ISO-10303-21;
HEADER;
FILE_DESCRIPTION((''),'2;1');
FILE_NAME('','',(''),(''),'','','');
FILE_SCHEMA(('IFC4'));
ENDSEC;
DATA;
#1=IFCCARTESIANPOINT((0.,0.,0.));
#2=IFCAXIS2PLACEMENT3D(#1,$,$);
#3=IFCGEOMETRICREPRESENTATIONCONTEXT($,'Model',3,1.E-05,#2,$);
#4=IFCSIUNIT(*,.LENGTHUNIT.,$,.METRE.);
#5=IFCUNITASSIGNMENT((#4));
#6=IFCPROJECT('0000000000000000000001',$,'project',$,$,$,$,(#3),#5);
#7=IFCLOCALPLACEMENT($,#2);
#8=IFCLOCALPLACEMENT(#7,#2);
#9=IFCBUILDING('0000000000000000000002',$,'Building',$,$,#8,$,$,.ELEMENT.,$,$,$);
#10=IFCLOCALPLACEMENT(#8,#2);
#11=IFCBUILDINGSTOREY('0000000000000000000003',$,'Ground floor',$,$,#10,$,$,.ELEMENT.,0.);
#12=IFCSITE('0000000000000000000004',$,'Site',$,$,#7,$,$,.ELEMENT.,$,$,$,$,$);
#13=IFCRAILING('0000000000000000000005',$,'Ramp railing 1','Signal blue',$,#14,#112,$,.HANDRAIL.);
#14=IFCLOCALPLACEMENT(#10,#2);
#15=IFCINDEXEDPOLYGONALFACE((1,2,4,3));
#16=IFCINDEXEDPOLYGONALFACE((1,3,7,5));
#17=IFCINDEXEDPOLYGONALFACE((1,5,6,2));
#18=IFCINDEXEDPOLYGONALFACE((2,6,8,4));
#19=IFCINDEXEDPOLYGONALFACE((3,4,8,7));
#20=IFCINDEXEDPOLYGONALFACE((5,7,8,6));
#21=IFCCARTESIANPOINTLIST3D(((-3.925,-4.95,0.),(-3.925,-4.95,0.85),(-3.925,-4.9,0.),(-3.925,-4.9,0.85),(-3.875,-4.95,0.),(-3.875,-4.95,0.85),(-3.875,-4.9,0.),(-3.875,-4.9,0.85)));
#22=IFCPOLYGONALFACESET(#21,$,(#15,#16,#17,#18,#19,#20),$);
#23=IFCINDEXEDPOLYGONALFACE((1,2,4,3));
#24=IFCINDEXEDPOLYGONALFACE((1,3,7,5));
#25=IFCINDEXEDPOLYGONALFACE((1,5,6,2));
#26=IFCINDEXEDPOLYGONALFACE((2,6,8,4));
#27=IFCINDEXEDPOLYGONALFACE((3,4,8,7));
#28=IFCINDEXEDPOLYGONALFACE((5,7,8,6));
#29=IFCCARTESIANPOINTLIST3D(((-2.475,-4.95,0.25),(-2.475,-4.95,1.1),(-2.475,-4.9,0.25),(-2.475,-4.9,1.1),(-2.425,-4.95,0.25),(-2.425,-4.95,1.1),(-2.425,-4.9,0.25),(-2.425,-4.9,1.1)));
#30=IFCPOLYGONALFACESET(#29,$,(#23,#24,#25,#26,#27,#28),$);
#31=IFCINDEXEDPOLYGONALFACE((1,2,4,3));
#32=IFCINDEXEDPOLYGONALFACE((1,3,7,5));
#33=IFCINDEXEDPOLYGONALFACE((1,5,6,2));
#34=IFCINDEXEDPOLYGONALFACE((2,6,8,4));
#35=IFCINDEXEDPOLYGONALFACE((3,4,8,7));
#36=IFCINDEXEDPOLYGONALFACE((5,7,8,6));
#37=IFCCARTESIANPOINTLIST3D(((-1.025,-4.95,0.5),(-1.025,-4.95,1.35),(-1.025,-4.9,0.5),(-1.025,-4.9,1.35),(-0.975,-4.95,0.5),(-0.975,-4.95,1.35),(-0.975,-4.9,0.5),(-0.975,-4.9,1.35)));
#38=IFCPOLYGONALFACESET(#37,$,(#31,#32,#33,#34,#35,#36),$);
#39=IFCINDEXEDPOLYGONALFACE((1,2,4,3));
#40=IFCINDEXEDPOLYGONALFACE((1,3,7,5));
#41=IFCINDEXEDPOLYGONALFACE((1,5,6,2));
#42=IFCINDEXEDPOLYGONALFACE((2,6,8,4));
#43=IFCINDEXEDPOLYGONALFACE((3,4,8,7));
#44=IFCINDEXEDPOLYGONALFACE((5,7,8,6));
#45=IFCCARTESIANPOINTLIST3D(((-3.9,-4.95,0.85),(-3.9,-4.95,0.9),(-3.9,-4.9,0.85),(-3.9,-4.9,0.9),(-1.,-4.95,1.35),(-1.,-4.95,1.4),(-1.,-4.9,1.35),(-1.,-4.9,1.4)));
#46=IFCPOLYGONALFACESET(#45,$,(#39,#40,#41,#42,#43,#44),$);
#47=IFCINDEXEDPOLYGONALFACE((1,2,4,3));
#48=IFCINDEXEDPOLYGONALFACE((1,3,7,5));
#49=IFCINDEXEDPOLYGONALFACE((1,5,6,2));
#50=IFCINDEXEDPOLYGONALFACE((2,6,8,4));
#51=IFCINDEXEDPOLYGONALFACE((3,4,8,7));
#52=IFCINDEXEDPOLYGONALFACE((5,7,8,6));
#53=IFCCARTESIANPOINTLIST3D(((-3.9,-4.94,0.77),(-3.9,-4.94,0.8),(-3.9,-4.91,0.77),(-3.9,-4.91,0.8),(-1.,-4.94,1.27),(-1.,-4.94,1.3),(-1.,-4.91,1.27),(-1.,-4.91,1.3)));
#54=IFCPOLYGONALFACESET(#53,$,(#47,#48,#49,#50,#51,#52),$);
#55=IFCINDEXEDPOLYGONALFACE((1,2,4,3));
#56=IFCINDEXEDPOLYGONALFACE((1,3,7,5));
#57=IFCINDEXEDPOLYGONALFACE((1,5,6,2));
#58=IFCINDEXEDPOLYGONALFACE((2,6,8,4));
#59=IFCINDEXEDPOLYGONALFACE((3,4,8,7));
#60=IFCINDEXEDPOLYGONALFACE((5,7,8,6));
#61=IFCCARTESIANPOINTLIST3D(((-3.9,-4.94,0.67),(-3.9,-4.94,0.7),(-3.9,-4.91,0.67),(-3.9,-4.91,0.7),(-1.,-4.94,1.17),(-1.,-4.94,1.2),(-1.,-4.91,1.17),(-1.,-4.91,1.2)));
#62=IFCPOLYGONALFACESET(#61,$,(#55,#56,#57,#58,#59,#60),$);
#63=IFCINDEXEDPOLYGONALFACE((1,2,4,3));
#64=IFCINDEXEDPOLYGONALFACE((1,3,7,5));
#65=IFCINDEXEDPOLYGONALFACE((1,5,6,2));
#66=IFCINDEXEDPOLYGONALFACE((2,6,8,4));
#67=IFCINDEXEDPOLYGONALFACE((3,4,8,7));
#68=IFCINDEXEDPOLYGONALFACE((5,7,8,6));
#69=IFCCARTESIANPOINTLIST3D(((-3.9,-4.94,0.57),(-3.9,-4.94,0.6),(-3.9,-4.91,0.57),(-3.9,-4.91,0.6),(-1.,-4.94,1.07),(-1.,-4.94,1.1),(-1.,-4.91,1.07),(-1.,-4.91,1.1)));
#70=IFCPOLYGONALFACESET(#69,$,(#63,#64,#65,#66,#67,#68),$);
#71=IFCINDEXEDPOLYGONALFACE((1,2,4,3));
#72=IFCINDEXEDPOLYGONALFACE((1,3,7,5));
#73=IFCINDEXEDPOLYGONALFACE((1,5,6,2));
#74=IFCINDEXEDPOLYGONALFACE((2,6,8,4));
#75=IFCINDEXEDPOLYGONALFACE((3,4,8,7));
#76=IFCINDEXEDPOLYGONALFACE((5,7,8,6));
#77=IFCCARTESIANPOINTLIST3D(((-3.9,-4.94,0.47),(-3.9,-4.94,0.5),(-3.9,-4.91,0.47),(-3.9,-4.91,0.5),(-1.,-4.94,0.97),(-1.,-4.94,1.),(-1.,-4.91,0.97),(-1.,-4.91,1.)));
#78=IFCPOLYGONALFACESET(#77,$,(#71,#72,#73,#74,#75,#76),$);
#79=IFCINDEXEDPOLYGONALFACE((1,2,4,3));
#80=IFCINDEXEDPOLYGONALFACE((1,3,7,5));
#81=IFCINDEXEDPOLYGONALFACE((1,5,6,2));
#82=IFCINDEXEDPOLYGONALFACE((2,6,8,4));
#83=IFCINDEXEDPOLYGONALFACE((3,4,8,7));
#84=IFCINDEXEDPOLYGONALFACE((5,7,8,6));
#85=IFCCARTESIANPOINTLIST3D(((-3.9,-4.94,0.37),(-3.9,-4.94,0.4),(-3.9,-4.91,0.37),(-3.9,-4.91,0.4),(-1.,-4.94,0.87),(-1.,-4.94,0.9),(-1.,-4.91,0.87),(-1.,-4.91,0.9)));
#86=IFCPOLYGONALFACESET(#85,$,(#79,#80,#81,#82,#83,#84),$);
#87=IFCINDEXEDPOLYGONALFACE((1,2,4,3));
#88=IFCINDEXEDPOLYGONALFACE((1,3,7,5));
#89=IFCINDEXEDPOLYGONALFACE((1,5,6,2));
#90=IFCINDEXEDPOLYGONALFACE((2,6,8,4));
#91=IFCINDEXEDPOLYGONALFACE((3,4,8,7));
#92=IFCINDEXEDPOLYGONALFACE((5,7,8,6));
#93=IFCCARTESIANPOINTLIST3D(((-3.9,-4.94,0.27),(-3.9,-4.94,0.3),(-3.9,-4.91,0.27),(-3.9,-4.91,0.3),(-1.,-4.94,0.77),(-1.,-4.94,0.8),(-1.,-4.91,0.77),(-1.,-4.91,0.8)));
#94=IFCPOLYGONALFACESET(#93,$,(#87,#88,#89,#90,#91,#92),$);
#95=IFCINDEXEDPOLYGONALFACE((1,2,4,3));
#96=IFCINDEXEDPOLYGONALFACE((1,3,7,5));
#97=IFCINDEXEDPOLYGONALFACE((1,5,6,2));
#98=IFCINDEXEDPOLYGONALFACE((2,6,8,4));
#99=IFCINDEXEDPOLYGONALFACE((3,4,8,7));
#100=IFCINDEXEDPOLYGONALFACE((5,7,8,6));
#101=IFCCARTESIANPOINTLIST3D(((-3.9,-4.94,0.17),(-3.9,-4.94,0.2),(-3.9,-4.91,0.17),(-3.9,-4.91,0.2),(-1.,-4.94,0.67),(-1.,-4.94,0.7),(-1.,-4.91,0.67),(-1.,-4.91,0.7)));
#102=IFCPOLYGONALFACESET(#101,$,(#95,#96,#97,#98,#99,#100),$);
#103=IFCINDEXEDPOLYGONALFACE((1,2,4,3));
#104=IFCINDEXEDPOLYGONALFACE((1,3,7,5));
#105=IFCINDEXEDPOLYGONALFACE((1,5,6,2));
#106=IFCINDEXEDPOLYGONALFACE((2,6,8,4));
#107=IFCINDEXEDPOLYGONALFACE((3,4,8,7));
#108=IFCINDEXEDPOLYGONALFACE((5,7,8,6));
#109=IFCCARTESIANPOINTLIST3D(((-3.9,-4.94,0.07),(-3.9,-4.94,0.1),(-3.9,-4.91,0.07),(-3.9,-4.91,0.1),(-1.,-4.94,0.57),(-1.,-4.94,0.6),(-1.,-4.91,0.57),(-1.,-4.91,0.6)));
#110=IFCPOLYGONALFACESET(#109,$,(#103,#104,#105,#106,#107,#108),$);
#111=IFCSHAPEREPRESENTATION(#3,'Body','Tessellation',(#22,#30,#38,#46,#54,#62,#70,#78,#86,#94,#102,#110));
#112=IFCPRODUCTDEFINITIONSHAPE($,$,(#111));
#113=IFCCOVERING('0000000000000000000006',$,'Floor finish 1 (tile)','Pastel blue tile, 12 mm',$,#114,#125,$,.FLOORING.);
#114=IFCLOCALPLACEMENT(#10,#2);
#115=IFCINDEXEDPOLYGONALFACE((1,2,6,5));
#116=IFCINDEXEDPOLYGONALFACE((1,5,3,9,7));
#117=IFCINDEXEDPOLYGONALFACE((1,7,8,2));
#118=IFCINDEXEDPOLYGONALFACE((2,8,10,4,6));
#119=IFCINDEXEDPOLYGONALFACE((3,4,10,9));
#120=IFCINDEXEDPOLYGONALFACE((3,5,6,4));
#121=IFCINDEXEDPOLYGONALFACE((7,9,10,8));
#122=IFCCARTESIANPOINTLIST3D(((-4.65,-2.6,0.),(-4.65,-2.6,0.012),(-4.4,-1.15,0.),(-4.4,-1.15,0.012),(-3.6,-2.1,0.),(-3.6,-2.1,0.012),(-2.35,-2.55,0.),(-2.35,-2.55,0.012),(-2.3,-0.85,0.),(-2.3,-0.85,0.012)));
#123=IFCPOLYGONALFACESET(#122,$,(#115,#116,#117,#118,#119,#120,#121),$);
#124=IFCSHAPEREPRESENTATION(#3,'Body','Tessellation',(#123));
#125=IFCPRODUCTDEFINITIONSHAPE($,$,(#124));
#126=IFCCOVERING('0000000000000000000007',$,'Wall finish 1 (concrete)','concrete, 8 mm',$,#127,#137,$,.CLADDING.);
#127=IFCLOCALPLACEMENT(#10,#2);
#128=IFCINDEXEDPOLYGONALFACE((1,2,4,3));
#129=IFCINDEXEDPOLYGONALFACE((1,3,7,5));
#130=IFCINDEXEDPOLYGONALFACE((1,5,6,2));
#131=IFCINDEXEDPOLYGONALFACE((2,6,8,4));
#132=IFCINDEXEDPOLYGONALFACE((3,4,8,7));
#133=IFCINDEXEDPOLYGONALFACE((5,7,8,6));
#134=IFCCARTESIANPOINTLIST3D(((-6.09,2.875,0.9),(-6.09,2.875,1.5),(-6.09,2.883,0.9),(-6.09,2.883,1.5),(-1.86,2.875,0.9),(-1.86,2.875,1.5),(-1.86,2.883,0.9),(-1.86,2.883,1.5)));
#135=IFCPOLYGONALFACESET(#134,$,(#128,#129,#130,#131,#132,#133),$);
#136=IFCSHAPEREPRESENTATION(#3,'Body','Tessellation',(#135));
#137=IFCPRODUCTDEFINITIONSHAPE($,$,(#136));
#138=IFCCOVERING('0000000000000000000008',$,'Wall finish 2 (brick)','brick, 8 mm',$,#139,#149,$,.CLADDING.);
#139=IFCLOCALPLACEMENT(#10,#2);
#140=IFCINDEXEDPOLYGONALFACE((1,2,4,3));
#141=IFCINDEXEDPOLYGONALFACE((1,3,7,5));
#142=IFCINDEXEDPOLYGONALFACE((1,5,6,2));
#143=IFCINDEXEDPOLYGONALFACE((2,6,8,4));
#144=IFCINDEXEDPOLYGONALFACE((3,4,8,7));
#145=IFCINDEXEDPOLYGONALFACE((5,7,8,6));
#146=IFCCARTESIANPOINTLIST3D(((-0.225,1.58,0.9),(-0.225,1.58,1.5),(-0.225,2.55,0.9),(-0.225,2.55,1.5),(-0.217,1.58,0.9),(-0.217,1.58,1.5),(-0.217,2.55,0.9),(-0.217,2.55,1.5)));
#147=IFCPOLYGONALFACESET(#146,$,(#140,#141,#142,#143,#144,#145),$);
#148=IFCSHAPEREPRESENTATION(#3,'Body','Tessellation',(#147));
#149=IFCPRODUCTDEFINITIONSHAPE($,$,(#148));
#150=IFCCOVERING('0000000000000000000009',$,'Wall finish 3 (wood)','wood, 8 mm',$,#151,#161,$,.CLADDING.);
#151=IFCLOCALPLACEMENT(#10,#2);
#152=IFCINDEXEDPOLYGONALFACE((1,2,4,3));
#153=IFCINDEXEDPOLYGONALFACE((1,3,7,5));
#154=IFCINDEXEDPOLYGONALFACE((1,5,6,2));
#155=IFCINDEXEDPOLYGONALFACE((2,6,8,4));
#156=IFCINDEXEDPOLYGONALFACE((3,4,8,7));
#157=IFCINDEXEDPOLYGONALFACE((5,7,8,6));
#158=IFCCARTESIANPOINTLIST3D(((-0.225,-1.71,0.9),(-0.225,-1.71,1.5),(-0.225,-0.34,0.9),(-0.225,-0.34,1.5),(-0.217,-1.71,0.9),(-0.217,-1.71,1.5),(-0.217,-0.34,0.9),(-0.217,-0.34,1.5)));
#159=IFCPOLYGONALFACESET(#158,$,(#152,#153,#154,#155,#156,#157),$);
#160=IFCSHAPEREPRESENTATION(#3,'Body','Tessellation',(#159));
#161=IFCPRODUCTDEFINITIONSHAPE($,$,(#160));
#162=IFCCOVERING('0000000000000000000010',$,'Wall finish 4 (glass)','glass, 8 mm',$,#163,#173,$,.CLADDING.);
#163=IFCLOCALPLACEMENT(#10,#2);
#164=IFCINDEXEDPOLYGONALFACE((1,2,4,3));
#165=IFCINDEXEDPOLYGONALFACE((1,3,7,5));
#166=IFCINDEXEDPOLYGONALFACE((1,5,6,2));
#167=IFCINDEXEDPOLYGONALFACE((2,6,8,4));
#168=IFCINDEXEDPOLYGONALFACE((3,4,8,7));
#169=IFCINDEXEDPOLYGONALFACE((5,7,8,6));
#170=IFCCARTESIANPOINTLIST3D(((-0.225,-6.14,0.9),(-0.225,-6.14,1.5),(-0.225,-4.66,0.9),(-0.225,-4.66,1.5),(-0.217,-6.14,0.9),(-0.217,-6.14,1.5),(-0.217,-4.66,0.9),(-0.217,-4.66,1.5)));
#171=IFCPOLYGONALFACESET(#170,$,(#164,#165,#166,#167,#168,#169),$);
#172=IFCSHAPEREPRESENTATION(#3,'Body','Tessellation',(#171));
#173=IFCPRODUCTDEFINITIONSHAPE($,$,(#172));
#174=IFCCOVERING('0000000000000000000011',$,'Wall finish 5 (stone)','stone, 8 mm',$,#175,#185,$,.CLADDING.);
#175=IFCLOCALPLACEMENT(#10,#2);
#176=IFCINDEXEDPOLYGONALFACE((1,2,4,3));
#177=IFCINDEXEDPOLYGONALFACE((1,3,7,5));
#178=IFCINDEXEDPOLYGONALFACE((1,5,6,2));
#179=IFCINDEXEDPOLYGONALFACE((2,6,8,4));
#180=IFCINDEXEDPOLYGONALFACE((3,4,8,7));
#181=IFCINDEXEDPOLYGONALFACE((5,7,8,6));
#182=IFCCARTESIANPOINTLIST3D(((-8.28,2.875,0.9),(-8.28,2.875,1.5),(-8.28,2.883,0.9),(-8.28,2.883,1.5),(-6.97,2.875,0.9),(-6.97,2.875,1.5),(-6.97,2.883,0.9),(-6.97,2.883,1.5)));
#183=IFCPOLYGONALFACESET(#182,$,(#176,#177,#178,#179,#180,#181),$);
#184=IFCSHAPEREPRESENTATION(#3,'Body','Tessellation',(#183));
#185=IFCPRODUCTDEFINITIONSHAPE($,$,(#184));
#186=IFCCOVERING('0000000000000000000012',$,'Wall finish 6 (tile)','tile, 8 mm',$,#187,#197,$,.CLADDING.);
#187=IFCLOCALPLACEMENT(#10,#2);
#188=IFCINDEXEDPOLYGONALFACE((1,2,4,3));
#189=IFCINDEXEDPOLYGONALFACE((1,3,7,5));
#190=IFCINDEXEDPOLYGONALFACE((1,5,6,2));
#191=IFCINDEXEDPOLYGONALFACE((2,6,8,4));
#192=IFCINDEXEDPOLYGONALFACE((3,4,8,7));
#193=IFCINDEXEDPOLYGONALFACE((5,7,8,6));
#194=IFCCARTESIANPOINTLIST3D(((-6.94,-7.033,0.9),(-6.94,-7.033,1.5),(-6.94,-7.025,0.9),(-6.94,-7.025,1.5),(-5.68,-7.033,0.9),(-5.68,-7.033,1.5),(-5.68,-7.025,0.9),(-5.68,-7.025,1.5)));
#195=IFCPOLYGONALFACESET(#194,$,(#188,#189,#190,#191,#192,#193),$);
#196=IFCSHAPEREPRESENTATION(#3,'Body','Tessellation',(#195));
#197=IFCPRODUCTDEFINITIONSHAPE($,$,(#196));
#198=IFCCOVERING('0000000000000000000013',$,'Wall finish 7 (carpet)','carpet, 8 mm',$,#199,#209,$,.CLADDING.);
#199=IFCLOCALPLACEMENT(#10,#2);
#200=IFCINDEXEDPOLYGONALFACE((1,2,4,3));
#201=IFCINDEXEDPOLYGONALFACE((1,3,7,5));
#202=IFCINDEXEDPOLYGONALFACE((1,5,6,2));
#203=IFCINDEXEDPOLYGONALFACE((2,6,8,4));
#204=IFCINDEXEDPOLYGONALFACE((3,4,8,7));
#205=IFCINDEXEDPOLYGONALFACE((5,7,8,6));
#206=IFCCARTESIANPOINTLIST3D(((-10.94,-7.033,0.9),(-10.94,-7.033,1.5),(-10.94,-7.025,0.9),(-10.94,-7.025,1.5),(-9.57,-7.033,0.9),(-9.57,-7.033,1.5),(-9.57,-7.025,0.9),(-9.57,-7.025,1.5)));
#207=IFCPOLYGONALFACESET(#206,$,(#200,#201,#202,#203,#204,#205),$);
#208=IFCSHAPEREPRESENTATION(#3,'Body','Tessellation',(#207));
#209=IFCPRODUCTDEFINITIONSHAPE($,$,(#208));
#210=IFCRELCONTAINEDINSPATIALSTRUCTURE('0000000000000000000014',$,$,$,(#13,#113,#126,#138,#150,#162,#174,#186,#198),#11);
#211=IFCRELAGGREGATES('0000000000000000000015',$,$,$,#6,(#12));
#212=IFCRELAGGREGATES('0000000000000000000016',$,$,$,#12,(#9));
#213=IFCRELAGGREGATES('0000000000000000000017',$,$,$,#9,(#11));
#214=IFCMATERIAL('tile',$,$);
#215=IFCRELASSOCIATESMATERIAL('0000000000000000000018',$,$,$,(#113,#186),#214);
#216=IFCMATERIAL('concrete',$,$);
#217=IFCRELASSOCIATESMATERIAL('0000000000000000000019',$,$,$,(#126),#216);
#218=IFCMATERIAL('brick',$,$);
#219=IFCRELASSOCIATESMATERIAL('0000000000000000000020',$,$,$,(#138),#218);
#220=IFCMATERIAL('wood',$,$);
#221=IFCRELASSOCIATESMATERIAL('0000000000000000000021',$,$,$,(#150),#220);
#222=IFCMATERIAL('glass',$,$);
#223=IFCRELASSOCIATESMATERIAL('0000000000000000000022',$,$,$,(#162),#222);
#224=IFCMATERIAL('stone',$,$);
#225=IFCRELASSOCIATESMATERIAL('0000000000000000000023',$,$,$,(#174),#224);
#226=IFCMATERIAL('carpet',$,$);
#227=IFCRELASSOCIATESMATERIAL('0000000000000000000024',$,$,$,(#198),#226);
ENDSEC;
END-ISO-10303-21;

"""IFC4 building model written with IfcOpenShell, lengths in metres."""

from ifc_helpers import new_model, si_unit, frame, frame_2d, origin, origin_with_axes, place, context, project, spatial, polyline, rectangle, outline, extrude, material, element, save


model = new_model("IFC4")

# Units and contexts
model_context = context("Model", 3, precision=1e-05, world=origin())
ifc_project = project(units=[si_unit("LENGTHUNIT", "METRE")], contexts=[model_context])

# Site, building, storey
site_placement = place(None, origin())
site = spatial("IfcSite", under=ifc_project, at=site_placement, Name="Site", CompositionType="ELEMENT")
building_placement = place(site_placement, origin())
building = spatial("IfcBuilding", under=site, at=building_placement, Name="Building", CompositionType="ELEMENT")
storey_placement = place(building_placement, origin())
storey = spatial("IfcBuildingStorey", under=building, at=storey_placement, Name="Ground floor", CompositionType="ELEMENT", Elevation=0.0)

# Railing
railing_placement = place(storey_placement, frame((-3.9, -5.5, 0.0), z_axis=(0.0, 0.0, 1.0), x_axis=(1.0, 0.0, 0.0)))
element("IfcRailing", 1, at=railing_placement, inside=storey, Name="Ramp railing 1", Description="Signal blue", PredefinedType="HANDRAIL", context=model_context, shape_type="SweptSolid", body=[
    extrude(rectangle(XDim=0.05, YDim=0.05, at=frame_2d((0.0, 0.575))), origin(), (0.0, 0.0, 1.0), 0.85),
    extrude(rectangle(XDim=0.05, YDim=0.05, at=frame_2d((1.45, 0.575))), frame((0.0, 0.0, 0.25)), (0.0, 0.0, 1.0), 0.85),
    extrude(rectangle(XDim=0.05, YDim=0.05, at=frame_2d((2.9, 0.575))), frame((0.0, 0.0, 0.5)), (0.0, 0.0, 1.0), 0.85),
    extrude(outline(polyline([(0.0, 0.85), (2.9, 1.35), (2.9, 1.4), (0.0, 0.9), (0.0, 0.85)])), frame((0.0, 0.6, 0.0), z_axis=(0.0, -1.0, 0.0), x_axis=(1.0, 0.0, 0.0)), (0.0, 0.0, 1.0), 0.05),
    extrude(outline(polyline([(0.0, 0.77), (2.9, 1.27), (2.9, 1.3), (0.0, 0.8), (0.0, 0.77)])), frame((0.0, 0.59, 0.0), z_axis=(0.0, -1.0, 0.0), x_axis=(1.0, 0.0, 0.0)), (0.0, 0.0, 1.0), 0.03),
    extrude(outline(polyline([(0.0, 0.67), (2.9, 1.17), (2.9, 1.2), (0.0, 0.7), (0.0, 0.67)])), frame((0.0, 0.59, 0.0), z_axis=(0.0, -1.0, 0.0), x_axis=(1.0, 0.0, 0.0)), (0.0, 0.0, 1.0), 0.03),
    extrude(outline(polyline([(0.0, 0.57), (2.9, 1.07), (2.9, 1.1), (0.0, 0.6), (0.0, 0.57)])), frame((0.0, 0.59, 0.0), z_axis=(0.0, -1.0, 0.0), x_axis=(1.0, 0.0, 0.0)), (0.0, 0.0, 1.0), 0.03),
    extrude(outline(polyline([(0.0, 0.47), (2.9, 0.97), (2.9, 1.0), (0.0, 0.5), (0.0, 0.47)])), frame((0.0, 0.59, 0.0), z_axis=(0.0, -1.0, 0.0), x_axis=(1.0, 0.0, 0.0)), (0.0, 0.0, 1.0), 0.03),
    extrude(outline(polyline([(0.0, 0.37), (2.9, 0.87), (2.9, 0.9), (0.0, 0.4), (0.0, 0.37)])), frame((0.0, 0.59, 0.0), z_axis=(0.0, -1.0, 0.0), x_axis=(1.0, 0.0, 0.0)), (0.0, 0.0, 1.0), 0.03),
    extrude(outline(polyline([(0.0, 0.27), (2.9, 0.77), (2.9, 0.8), (0.0, 0.3), (0.0, 0.27)])), frame((0.0, 0.59, 0.0), z_axis=(0.0, -1.0, 0.0), x_axis=(1.0, 0.0, 0.0)), (0.0, 0.0, 1.0), 0.03),
    extrude(outline(polyline([(0.0, 0.17), (2.9, 0.67), (2.9, 0.7), (0.0, 0.2), (0.0, 0.17)])), frame((0.0, 0.59, 0.0), z_axis=(0.0, -1.0, 0.0), x_axis=(1.0, 0.0, 0.0)), (0.0, 0.0, 1.0), 0.03),
    extrude(outline(polyline([(0.0, 0.07), (2.9, 0.57), (2.9, 0.6), (0.0, 0.1), (0.0, 0.07)])), frame((0.0, 0.59, 0.0), z_axis=(0.0, -1.0, 0.0), x_axis=(1.0, 0.0, 0.0)), (0.0, 0.0, 1.0), 0.03),
])

# Coverings
ifc_material_1 = material(Name="tile")
covering_1_placement = place(storey_placement, origin_with_axes())
element("IfcCovering", 2, at=covering_1_placement, inside=storey, material=ifc_material_1, Name="Floor finish 1 (tile)", Description="Pastel blue tile, 12 mm", PredefinedType="FLOORING", context=model_context, shape_type="SweptSolid", body=[
    extrude(outline(polyline([(-3.6, -2.1), (-4.65, -2.6), (-2.35, -2.55), (-2.3, -0.85), (-4.4, -1.15), (-3.6, -2.1)])), origin(), (0.0, 0.0, 1.0), 0.012),
])
ifc_material_2 = material(Name="concrete")
covering_2_placement = place(storey_placement, origin_with_axes())
element("IfcCovering", 3, at=covering_2_placement, inside=storey, material=ifc_material_2, Name="Wall finish 1 (concrete)", Description="concrete, 8 mm", PredefinedType="CLADDING", context=model_context, shape_type="SweptSolid", body=[
    extrude(outline(polyline([(-6.09, 2.875), (-1.86, 2.875), (-1.86, 2.883), (-6.09, 2.883), (-6.09, 2.875)])), frame((0.0, 0.0, 0.9)), (0.0, 0.0, 1.0), 0.6),
])
ifc_material_3 = material(Name="brick")
covering_3_placement = place(storey_placement, origin_with_axes())
element("IfcCovering", 4, at=covering_3_placement, inside=storey, material=ifc_material_3, Name="Wall finish 2 (brick)", Description="brick, 8 mm", PredefinedType="CLADDING", context=model_context, shape_type="SweptSolid", body=[
    extrude(outline(polyline([(-0.225, 2.55), (-0.225, 1.58), (-0.217, 1.58), (-0.217, 2.55), (-0.225, 2.55)])), frame((0.0, 0.0, 0.9)), (0.0, 0.0, 1.0), 0.6),
])
ifc_material_4 = material(Name="wood")
covering_4_placement = place(storey_placement, origin_with_axes())
element("IfcCovering", 5, at=covering_4_placement, inside=storey, material=ifc_material_4, Name="Wall finish 3 (wood)", Description="wood, 8 mm", PredefinedType="CLADDING", context=model_context, shape_type="SweptSolid", body=[
    extrude(outline(polyline([(-0.225, -0.34), (-0.225, -1.71), (-0.217, -1.71), (-0.217, -0.34), (-0.225, -0.34)])), frame((0.0, 0.0, 0.9)), (0.0, 0.0, 1.0), 0.6),
])
ifc_material_5 = material(Name="glass")
covering_5_placement = place(storey_placement, origin_with_axes())
element("IfcCovering", 6, at=covering_5_placement, inside=storey, material=ifc_material_5, Name="Wall finish 4 (glass)", Description="glass, 8 mm", PredefinedType="CLADDING", context=model_context, shape_type="SweptSolid", body=[
    extrude(outline(polyline([(-0.225, -4.66), (-0.225, -6.14), (-0.217, -6.14), (-0.217, -4.66), (-0.225, -4.66)])), frame((0.0, 0.0, 0.9)), (0.0, 0.0, 1.0), 0.6),
])
ifc_material_6 = material(Name="stone")
covering_6_placement = place(storey_placement, origin_with_axes())
element("IfcCovering", 7, at=covering_6_placement, inside=storey, material=ifc_material_6, Name="Wall finish 5 (stone)", Description="stone, 8 mm", PredefinedType="CLADDING", context=model_context, shape_type="SweptSolid", body=[
    extrude(outline(polyline([(-8.28, 2.875), (-6.97, 2.875), (-6.97, 2.883), (-8.28, 2.883), (-8.28, 2.875)])), frame((0.0, 0.0, 0.9)), (0.0, 0.0, 1.0), 0.6),
])
covering_7_placement = place(storey_placement, origin_with_axes())
element("IfcCovering", 8, at=covering_7_placement, inside=storey, material=ifc_material_1, Name="Wall finish 6 (tile)", Description="tile, 8 mm", PredefinedType="CLADDING", context=model_context, shape_type="SweptSolid", body=[
    extrude(outline(polyline([(-5.68, -7.025), (-6.94, -7.025), (-6.94, -7.033), (-5.68, -7.033), (-5.68, -7.025)])), frame((0.0, 0.0, 0.9)), (0.0, 0.0, 1.0), 0.6),
])
ifc_material_7 = material(Name="carpet")
covering_8_placement = place(storey_placement, origin_with_axes())
element("IfcCovering", 9, at=covering_8_placement, inside=storey, material=ifc_material_7, Name="Wall finish 7 (carpet)", Description="carpet, 8 mm", PredefinedType="CLADDING", context=model_context, shape_type="SweptSolid", body=[
    extrude(outline(polyline([(-9.57, -7.025), (-10.94, -7.025), (-10.94, -7.033), (-9.57, -7.033), (-9.57, -7.025)])), frame((0.0, 0.0, 0.9)), (0.0, 0.0, 1.0), 0.6),
])

save(model, "model.ifc")
